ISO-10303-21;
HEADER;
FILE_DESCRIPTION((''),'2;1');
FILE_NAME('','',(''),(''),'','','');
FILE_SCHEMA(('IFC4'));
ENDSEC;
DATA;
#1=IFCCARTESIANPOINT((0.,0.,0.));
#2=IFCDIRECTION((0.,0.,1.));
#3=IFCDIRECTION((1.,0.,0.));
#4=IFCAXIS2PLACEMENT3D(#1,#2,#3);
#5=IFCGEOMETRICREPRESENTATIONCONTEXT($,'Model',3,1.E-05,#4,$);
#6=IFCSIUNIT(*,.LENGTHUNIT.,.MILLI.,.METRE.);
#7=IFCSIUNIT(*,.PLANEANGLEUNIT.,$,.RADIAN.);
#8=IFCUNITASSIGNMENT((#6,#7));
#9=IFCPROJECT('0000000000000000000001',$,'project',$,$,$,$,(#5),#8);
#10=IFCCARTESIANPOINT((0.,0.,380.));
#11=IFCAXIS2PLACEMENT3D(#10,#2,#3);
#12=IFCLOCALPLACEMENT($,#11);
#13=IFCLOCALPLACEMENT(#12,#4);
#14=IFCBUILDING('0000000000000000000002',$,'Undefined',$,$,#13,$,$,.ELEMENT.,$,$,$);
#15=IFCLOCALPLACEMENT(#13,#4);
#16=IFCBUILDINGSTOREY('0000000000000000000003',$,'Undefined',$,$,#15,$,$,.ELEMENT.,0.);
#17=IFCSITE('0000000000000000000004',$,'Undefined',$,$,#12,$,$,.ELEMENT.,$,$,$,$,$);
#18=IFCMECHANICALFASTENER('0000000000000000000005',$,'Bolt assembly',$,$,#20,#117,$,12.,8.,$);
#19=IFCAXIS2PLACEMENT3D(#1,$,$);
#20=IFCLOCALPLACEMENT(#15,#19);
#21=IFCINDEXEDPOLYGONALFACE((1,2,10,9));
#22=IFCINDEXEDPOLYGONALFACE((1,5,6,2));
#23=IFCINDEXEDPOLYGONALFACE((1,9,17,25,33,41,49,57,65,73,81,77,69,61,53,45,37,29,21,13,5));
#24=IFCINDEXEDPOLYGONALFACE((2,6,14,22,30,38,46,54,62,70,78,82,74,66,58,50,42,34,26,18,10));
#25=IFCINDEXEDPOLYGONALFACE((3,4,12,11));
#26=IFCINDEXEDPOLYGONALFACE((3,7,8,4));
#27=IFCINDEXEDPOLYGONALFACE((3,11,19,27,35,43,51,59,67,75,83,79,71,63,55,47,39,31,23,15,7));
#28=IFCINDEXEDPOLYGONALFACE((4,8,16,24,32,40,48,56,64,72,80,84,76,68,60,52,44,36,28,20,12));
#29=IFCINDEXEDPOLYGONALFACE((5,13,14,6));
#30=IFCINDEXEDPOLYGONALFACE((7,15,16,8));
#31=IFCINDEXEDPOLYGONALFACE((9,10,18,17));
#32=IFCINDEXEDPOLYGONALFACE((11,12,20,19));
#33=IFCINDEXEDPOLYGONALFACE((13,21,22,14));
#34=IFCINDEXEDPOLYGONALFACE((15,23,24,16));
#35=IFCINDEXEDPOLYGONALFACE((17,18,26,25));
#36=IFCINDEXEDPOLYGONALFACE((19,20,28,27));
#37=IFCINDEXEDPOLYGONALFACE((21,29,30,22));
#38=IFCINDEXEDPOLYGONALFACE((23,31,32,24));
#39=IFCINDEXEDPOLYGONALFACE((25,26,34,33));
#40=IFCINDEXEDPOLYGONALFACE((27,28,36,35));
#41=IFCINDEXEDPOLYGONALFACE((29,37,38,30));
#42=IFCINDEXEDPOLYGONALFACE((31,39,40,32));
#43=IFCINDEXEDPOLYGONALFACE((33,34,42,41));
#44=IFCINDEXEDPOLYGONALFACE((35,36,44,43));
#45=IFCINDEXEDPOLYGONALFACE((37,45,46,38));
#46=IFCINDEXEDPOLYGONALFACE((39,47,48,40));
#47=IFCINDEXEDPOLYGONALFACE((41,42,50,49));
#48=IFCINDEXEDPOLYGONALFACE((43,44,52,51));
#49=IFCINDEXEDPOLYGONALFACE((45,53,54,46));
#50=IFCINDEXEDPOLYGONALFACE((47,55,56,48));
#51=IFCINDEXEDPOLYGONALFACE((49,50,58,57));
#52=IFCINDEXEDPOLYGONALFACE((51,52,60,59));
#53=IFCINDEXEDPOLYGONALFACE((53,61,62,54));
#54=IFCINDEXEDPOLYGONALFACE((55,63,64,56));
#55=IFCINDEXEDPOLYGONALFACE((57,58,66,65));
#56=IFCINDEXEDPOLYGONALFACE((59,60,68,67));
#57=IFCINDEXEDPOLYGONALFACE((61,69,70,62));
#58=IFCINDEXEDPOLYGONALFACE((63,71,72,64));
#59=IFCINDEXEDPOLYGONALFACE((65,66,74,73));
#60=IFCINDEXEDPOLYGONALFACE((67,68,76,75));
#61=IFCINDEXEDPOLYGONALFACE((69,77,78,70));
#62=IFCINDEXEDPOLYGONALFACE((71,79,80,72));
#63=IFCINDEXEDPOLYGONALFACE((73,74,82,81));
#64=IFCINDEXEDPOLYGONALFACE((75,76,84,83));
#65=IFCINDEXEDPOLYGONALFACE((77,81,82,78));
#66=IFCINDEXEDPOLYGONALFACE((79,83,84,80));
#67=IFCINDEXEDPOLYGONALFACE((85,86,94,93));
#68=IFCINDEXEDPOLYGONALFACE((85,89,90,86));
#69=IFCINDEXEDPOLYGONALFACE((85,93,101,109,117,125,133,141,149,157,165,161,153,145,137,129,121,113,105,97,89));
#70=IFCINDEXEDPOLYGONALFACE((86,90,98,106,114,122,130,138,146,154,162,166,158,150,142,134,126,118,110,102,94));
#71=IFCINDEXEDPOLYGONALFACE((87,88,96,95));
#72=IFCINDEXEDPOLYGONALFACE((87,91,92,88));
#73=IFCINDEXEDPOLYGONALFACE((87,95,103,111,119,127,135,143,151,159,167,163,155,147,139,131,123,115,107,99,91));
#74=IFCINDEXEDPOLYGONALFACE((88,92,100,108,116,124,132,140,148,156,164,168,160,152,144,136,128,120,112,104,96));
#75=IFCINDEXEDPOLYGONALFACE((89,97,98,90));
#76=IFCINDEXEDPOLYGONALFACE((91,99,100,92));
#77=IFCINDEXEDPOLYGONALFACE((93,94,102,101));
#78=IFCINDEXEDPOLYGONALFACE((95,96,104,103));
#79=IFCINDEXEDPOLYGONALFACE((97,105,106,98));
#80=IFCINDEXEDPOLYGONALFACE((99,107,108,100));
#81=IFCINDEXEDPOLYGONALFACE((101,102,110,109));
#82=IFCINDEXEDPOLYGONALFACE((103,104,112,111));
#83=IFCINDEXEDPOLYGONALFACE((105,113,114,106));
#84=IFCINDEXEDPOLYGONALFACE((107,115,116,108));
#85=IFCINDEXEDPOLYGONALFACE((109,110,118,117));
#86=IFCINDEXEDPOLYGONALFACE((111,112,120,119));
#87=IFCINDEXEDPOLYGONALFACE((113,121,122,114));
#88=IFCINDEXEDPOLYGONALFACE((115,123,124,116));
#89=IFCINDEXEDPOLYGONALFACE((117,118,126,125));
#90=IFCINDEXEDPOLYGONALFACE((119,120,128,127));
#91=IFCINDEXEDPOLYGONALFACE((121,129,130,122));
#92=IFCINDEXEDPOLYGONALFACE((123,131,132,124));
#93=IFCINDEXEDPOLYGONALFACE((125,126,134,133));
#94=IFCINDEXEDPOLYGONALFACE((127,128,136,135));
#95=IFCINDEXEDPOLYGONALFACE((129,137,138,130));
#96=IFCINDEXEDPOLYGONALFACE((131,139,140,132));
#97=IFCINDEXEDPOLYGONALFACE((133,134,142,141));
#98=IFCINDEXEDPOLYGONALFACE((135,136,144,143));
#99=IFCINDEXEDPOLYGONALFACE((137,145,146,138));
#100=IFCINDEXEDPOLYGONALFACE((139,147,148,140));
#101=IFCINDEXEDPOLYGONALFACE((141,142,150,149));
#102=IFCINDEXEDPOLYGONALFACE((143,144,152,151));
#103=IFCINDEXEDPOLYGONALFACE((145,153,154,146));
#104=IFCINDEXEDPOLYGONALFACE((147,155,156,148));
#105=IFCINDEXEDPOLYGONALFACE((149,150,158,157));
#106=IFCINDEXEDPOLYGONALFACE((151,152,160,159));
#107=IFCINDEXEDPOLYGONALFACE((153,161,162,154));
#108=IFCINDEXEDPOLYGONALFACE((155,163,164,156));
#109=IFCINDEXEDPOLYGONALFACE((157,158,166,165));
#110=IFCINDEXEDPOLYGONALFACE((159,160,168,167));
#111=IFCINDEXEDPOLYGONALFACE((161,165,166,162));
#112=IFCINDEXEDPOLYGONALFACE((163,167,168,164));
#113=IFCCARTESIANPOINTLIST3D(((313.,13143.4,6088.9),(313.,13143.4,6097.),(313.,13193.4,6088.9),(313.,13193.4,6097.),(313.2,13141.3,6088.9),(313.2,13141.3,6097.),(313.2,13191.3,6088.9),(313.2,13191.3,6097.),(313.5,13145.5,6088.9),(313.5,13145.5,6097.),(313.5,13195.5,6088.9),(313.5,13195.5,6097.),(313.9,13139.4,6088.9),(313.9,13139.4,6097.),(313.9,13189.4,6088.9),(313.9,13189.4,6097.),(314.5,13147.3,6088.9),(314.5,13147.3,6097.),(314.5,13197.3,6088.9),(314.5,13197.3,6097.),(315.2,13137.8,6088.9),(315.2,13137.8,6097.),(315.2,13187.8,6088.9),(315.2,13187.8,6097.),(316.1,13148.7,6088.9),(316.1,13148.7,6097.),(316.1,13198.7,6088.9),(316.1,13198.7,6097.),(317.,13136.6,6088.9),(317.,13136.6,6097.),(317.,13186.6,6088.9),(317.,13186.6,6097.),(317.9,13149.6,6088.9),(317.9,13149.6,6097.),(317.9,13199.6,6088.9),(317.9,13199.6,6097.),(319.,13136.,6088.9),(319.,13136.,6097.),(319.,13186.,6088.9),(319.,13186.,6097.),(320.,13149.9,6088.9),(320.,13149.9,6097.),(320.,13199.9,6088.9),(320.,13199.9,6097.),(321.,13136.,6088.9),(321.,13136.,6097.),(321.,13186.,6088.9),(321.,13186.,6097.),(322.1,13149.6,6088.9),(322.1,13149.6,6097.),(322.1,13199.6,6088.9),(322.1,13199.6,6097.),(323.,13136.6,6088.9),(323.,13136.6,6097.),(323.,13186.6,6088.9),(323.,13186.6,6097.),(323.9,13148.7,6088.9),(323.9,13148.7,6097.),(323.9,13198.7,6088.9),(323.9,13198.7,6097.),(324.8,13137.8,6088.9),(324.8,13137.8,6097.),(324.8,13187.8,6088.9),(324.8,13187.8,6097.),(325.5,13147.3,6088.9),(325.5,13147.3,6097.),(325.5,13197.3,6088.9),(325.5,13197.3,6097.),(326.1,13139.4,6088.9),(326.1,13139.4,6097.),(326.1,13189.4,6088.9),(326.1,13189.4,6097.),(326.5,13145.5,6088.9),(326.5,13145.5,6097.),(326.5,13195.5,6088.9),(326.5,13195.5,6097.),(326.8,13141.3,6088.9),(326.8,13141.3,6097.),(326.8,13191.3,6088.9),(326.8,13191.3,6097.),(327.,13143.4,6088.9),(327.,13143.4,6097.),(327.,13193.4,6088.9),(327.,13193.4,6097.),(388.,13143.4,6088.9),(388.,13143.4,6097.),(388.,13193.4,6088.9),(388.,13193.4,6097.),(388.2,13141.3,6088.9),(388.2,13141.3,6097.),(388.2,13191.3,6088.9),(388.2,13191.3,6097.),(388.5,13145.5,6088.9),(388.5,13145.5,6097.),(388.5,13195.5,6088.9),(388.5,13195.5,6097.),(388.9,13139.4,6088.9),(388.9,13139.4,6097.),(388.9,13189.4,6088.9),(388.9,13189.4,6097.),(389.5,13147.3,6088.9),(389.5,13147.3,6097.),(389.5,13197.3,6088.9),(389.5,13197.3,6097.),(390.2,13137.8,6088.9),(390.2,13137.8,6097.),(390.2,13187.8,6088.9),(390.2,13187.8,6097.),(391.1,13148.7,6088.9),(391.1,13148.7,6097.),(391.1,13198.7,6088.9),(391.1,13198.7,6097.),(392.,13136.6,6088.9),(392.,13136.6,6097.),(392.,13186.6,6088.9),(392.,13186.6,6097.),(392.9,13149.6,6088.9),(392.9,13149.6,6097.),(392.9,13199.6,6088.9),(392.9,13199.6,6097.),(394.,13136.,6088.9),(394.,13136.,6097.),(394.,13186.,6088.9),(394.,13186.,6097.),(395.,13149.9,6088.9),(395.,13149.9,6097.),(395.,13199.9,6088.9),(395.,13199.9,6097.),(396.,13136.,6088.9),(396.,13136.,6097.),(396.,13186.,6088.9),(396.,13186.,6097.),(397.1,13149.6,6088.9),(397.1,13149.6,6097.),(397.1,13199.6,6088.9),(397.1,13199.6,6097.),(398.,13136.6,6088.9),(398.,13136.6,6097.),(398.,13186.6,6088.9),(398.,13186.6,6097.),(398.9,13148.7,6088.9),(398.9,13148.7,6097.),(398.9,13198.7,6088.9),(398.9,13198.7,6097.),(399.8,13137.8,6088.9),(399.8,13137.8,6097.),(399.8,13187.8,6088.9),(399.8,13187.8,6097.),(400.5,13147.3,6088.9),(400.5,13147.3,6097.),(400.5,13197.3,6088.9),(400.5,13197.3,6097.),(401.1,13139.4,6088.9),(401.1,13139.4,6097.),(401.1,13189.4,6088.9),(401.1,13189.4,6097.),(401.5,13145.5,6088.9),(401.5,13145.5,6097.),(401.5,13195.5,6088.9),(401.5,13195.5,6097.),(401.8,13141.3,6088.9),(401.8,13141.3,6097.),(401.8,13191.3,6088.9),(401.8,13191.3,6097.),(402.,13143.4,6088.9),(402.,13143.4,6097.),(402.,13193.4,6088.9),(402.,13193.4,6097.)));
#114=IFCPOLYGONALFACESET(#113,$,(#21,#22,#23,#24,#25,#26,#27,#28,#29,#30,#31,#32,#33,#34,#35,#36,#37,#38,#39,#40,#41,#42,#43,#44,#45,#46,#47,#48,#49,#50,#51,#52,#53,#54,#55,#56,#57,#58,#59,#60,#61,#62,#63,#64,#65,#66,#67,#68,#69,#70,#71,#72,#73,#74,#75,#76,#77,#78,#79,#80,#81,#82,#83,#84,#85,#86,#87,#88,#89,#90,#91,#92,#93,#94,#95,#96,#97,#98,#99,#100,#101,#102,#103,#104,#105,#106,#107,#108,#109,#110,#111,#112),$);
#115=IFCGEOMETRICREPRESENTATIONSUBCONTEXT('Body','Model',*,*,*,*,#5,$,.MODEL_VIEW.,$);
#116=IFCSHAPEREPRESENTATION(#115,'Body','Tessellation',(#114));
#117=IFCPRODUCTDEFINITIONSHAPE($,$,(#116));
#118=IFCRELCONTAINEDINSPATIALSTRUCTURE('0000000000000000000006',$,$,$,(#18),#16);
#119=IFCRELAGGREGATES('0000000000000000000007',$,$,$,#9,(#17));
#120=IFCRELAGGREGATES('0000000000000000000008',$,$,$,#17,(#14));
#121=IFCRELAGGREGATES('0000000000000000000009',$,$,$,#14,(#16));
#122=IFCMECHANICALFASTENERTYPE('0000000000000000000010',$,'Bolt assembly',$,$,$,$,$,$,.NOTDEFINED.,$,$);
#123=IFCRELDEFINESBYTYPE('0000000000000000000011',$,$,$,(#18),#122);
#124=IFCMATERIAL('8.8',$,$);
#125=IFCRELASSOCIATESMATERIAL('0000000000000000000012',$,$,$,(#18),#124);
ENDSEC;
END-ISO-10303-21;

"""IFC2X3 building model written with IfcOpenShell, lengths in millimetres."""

from ifc_helpers import new_model, si_unit, frame, origin_with_axes, origin_2d_with_axis, place, context, subcontext, project, spatial, circle, extrude, source, transform, mapped, material, type_object, element, save


model = new_model("IFC2X3")

# Units and contexts
model_context = context("Model", 3, precision=1e-05, world=origin_with_axes())
body_context = subcontext(model_context, "Body", "Model", "MODEL_VIEW")
ifc_project = project(units=[si_unit("LENGTHUNIT", "METRE", prefix="MILLI"), si_unit("PLANEANGLEUNIT", "RADIAN")], contexts=[model_context])

# Site, building, storey
site_placement = place(None, frame((0.0, 0.0, 380.0), z_axis=(0.0, 0.0, 1.0), x_axis=(1.0, 0.0, 0.0)))
site = spatial("IfcSite", under=ifc_project, at=site_placement, Name="Undefined", CompositionType="ELEMENT")
building_placement = place(site_placement, origin_with_axes())
building = spatial("IfcBuilding", under=site, at=building_placement, Name="Undefined", CompositionType="ELEMENT")
storey_placement = place(building_placement, origin_with_axes())
storey = spatial("IfcBuildingStorey", under=building, at=storey_placement, Name="Undefined", CompositionType="ELEMENT", Elevation=0.0)

# Mechanical fastener
ifc_material_1 = material(Name="8.8")
mechanical_fastener_type = type_object("IfcMechanicalFastenerType", Name="Bolt assembly")
shared_shape = source(origin_with_axes(), body_context, "Body", "SweptSolid", [
    extrude(circle(Radius=7.0, at=origin_2d_with_axis()), frame((0.0, 0.0, 0.0), z_axis=(0.0, 1.0, 0.0), x_axis=(1.0, 0.0, 0.0)), (0.0, 0.0, 1.0), 8.1),
])
mechanical_fastener_1_placement = place(storey_placement, frame((357.5, 13142.9, 6097.0), z_axis=(-1.0, 0.0, 0.0), x_axis=(0.0, 1.0, 0.0)))
element("IfcMechanicalFastener", 1, at=mechanical_fastener_1_placement, inside=storey, type_object=mechanical_fastener_type, material=ifc_material_1, Name="Bolt assembly", NominalDiameter=12.0, NominalLength=8.0, context=body_context, shape_type="MappedRepresentation", body=[
    mapped(shared_shape, transform((0.0, 0.0, -37.5))),
    mapped(shared_shape, transform((50.0, 0.0, -37.5))),
    mapped(shared_shape, transform((0.0, 0.0, 37.5))),
    mapped(shared_shape, transform((50.0, 0.0, 37.5))),
])

save(model, "model.ifc")
